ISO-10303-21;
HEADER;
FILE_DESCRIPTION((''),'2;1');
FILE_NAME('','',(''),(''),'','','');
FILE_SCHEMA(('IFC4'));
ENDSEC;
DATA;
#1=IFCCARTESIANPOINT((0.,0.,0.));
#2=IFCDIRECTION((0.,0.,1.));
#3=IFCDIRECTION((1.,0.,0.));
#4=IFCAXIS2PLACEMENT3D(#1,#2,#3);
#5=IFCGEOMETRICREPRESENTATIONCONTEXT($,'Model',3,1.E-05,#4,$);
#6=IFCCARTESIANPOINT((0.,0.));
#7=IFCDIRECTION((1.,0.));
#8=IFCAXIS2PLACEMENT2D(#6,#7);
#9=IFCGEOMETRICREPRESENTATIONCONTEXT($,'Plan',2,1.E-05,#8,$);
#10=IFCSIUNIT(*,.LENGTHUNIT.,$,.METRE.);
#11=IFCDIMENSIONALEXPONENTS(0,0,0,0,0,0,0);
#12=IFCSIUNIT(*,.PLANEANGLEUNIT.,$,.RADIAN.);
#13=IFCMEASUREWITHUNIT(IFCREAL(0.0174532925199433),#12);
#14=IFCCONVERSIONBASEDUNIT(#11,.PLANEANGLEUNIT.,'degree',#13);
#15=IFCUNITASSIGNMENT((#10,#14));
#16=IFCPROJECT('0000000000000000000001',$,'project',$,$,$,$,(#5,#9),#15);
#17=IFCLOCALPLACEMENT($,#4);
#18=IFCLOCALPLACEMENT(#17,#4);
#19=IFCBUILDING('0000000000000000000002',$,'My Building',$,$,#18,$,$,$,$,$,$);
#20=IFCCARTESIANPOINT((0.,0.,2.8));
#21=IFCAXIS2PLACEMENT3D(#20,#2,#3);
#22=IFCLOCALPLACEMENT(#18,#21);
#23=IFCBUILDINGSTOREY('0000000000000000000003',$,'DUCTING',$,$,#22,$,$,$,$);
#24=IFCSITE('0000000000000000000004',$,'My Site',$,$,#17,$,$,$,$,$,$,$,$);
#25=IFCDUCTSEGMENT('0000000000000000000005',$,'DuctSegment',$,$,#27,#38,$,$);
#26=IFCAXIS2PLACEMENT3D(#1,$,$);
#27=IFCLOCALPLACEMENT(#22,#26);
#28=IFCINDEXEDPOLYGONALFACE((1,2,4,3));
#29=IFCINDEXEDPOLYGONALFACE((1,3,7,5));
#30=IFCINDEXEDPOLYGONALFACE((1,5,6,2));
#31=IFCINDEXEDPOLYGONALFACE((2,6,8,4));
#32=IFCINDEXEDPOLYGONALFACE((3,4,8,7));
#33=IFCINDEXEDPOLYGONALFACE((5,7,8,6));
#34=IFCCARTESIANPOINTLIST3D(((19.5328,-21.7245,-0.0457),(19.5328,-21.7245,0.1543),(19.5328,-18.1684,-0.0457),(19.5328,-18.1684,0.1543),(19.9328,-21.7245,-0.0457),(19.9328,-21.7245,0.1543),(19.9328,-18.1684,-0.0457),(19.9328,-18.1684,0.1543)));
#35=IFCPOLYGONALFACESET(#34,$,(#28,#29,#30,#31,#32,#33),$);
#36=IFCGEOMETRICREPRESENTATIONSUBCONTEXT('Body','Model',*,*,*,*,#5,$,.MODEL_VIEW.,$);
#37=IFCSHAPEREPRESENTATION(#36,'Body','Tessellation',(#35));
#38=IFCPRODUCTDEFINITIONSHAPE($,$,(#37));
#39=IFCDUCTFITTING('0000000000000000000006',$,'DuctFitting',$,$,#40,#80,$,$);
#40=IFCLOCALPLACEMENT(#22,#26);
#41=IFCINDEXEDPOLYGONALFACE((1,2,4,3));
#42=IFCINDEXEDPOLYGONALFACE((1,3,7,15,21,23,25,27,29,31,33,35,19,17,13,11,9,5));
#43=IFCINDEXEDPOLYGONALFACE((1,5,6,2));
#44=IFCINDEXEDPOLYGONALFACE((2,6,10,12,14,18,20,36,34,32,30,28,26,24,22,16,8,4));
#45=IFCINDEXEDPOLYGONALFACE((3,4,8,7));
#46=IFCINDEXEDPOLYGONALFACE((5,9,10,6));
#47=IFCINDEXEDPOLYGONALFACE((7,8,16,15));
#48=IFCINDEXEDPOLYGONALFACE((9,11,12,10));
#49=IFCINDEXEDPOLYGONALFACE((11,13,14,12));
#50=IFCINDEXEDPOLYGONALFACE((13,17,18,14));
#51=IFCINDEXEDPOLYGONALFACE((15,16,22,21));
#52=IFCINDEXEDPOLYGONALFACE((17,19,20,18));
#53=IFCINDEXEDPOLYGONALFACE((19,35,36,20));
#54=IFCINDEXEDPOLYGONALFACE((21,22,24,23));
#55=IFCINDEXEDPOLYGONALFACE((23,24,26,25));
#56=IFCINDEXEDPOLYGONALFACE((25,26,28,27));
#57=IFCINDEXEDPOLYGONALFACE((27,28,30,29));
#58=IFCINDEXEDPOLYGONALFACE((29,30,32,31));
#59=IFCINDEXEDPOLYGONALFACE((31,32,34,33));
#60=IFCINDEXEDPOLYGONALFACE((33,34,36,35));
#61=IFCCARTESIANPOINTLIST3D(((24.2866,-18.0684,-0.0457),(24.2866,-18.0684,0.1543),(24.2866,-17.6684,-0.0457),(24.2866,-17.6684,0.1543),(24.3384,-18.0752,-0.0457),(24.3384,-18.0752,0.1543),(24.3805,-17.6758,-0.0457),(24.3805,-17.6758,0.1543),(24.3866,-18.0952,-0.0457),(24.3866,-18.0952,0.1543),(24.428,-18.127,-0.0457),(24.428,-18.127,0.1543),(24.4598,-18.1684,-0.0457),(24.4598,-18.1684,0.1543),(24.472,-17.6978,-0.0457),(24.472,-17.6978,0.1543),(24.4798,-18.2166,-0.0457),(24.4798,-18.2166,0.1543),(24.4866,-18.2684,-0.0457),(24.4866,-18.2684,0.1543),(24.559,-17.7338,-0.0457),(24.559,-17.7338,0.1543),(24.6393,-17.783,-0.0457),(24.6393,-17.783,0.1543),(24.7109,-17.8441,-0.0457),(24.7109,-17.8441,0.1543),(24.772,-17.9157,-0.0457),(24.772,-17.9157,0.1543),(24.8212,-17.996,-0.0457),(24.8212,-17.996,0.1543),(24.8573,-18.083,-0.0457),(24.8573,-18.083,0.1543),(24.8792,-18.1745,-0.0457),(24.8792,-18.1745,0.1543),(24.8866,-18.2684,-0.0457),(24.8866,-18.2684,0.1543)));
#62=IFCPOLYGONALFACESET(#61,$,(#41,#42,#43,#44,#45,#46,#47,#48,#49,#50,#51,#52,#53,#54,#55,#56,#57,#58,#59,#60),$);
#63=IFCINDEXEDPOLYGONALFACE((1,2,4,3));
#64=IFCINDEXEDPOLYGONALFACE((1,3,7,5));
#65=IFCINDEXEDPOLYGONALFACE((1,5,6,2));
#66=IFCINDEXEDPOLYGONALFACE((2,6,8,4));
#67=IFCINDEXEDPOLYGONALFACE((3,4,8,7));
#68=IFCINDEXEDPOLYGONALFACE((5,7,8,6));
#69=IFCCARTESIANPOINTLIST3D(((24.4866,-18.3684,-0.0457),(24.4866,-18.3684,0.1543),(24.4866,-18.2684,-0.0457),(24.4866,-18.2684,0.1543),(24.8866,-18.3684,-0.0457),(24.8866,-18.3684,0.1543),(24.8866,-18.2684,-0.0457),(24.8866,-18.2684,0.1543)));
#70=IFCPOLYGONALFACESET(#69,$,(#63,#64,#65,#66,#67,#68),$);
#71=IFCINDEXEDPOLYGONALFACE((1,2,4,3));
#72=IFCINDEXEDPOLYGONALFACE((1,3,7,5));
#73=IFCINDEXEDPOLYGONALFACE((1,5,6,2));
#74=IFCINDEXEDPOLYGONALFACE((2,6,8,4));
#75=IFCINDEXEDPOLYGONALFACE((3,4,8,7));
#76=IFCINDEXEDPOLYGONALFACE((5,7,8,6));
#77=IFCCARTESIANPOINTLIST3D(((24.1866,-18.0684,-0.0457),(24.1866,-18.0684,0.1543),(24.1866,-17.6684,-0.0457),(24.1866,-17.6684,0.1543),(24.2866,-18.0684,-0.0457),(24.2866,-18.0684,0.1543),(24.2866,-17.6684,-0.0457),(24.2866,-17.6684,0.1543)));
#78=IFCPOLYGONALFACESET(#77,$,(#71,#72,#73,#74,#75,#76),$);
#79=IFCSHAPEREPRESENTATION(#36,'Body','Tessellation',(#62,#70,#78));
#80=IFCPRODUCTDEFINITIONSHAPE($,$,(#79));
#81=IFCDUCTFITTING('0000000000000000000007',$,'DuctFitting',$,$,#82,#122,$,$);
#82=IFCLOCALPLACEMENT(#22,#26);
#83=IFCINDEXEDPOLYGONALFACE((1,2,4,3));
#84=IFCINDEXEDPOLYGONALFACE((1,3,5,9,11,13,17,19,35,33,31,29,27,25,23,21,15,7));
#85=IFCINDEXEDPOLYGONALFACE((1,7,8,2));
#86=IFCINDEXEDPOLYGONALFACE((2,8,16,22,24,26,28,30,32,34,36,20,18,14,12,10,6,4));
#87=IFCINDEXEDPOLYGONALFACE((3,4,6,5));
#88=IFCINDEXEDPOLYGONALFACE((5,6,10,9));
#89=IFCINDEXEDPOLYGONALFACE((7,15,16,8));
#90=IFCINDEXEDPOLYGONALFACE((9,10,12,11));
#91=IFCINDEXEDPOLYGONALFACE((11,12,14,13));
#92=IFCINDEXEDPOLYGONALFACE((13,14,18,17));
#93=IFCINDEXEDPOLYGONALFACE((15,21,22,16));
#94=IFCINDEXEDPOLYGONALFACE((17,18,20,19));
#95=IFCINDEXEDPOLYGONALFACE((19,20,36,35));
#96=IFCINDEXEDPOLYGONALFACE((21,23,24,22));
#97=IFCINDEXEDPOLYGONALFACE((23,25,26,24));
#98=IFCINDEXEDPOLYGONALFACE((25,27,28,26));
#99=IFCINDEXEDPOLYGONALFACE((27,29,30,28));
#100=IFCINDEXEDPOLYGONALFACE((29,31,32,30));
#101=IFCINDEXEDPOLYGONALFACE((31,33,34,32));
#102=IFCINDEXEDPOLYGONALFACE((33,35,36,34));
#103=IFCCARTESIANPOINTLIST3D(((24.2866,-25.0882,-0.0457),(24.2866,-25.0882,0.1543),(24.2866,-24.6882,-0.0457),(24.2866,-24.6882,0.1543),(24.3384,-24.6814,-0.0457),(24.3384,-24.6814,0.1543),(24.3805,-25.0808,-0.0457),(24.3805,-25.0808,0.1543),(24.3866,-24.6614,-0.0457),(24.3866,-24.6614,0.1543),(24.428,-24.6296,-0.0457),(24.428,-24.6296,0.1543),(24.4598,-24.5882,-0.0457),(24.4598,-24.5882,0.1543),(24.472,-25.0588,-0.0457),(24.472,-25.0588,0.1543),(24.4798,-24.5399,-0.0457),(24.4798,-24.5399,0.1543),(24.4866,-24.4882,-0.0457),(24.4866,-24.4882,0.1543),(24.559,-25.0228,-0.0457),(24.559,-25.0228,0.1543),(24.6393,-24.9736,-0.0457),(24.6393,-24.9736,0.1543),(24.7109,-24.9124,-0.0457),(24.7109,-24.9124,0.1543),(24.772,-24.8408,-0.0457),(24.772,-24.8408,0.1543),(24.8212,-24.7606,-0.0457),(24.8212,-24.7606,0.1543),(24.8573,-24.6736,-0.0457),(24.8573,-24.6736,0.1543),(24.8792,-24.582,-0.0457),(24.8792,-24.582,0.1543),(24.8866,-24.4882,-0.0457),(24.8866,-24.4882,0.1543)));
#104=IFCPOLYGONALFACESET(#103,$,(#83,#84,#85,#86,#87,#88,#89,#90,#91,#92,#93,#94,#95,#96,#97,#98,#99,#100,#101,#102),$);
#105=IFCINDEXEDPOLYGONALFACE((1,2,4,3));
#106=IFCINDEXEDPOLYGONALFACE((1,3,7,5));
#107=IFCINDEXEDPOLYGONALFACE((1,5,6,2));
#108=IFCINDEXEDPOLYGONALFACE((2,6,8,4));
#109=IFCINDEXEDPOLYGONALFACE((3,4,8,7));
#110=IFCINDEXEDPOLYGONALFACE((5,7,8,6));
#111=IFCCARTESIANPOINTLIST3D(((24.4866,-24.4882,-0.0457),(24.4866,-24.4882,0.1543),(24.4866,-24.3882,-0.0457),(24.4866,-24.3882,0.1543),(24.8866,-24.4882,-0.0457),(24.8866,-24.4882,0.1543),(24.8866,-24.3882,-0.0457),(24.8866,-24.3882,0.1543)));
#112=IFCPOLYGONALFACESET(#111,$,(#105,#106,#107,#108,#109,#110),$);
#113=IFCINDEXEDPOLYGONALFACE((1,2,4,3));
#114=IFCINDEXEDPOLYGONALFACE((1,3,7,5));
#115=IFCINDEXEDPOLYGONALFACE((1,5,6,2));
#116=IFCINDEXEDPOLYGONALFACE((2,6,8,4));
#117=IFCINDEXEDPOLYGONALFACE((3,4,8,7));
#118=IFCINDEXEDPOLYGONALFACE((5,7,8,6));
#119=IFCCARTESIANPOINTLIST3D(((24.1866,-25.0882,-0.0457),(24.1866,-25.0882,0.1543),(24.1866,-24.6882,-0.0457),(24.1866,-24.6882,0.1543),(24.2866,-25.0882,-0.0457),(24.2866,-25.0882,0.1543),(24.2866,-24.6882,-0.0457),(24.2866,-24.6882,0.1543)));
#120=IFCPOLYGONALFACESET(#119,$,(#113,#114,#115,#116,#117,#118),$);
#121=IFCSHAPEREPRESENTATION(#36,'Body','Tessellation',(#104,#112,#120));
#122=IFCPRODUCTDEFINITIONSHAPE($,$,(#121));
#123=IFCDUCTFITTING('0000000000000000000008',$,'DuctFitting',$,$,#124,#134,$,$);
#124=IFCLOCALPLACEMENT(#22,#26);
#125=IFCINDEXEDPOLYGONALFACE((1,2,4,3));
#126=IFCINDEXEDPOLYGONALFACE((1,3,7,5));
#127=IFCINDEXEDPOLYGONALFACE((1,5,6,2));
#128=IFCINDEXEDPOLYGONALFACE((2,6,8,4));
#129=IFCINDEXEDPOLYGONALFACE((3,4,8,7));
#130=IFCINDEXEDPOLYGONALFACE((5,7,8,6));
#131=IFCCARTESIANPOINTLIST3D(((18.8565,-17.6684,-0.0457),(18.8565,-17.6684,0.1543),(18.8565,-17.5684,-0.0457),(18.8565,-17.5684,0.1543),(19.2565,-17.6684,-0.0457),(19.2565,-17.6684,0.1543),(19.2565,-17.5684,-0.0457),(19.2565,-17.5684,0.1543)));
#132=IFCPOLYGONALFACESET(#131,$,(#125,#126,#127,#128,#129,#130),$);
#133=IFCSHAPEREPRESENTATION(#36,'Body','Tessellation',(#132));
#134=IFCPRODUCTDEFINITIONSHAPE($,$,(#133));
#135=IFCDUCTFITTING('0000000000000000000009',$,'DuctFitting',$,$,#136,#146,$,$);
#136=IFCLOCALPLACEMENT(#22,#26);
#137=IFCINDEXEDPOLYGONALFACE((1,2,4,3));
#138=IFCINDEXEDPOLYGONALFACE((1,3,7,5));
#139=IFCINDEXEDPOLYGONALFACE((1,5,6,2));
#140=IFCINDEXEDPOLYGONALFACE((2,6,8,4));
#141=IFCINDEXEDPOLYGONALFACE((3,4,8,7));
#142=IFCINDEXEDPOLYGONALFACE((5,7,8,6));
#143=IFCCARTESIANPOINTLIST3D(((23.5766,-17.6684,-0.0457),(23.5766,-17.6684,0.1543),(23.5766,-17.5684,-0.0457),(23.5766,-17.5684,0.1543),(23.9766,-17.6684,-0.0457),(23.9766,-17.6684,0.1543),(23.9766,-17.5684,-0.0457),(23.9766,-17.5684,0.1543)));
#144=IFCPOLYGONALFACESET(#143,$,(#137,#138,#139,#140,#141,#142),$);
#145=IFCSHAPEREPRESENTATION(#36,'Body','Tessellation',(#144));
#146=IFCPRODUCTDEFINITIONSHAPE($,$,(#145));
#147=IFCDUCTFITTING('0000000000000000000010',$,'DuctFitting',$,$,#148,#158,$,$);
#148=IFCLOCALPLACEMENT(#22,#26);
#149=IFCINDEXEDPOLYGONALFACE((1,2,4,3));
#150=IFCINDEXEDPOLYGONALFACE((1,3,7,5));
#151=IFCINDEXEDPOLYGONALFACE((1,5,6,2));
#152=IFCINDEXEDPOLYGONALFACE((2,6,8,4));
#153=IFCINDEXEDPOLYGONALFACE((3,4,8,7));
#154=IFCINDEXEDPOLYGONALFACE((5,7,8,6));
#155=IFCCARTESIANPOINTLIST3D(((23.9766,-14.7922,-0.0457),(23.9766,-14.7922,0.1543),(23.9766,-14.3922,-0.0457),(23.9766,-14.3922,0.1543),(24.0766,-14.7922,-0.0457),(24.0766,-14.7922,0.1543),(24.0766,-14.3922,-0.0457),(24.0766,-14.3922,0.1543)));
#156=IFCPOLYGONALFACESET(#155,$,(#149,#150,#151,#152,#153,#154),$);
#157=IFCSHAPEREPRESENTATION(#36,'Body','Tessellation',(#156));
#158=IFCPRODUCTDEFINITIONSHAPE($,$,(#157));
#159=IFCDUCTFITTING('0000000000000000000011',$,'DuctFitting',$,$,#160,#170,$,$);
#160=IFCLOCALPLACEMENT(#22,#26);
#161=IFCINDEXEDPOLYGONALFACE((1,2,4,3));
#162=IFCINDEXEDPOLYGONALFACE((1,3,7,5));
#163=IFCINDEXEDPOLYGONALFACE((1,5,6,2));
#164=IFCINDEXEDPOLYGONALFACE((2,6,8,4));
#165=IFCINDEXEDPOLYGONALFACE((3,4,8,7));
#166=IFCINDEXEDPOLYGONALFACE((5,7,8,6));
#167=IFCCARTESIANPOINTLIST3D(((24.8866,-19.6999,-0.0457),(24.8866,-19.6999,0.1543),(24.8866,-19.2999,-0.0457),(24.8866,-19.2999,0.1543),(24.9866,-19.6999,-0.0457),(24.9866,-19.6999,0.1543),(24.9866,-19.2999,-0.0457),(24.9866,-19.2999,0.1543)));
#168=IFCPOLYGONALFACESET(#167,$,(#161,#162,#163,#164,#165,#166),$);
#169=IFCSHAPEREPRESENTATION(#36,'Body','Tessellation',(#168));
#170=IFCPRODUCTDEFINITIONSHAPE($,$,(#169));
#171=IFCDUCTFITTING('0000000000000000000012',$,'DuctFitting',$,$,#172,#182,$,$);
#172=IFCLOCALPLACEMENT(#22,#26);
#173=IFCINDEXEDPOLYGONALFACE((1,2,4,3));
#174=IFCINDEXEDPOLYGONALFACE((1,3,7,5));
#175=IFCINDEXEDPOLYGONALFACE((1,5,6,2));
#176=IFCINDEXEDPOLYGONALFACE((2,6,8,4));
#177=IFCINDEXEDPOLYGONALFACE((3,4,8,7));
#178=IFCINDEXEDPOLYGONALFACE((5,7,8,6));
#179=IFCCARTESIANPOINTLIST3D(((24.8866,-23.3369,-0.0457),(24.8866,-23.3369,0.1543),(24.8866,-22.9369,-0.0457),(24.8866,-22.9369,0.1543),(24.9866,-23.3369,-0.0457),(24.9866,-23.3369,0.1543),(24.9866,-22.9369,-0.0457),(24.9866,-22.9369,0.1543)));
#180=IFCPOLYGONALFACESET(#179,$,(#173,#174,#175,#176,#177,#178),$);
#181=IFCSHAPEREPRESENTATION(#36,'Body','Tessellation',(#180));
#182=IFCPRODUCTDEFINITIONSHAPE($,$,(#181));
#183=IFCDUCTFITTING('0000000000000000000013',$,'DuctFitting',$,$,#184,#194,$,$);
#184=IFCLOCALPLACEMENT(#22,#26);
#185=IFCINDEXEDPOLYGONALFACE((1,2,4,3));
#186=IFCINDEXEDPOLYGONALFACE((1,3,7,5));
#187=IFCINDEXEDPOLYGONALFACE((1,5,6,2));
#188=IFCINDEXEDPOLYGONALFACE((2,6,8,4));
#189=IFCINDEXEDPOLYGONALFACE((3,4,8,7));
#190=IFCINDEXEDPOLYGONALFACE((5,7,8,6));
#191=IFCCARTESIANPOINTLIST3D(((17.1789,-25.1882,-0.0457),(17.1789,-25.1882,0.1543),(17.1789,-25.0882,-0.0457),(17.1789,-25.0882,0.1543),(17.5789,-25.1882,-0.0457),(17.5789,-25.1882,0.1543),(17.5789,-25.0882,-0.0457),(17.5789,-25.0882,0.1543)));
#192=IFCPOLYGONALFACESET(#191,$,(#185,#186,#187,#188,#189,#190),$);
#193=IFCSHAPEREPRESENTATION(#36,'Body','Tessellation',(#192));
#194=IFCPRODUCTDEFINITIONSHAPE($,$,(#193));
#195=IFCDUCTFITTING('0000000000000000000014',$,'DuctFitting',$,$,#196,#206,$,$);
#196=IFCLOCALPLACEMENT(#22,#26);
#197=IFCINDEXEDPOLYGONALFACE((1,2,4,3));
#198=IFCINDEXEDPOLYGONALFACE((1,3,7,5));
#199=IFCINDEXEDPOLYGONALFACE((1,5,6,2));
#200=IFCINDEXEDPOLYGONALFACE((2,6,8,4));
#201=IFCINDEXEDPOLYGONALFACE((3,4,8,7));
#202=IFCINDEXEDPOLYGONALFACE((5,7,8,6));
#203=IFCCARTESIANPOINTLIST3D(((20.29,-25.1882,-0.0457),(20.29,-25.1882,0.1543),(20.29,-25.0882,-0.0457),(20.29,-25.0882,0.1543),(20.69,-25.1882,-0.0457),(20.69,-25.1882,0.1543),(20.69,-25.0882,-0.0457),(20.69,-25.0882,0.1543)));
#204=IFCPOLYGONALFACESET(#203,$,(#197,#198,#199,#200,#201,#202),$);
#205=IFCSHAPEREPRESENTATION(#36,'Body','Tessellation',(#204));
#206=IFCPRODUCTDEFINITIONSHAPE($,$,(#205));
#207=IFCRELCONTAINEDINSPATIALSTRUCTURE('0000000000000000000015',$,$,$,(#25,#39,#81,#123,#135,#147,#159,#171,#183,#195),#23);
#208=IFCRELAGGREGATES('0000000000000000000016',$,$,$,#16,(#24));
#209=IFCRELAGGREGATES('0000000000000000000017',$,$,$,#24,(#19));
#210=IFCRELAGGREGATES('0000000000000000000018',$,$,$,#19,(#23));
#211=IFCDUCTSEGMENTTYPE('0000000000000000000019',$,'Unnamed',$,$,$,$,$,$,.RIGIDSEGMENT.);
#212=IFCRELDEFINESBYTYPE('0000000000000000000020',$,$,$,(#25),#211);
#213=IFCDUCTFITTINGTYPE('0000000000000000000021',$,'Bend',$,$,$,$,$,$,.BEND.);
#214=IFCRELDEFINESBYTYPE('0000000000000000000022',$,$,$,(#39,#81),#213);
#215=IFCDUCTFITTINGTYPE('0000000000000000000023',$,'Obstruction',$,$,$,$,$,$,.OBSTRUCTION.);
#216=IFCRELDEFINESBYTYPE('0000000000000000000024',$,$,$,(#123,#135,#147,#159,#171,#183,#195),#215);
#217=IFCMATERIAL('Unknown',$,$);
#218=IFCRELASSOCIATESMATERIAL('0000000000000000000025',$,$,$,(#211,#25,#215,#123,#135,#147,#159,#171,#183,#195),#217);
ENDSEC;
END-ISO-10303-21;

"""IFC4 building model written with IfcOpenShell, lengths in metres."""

from ifc_helpers import new_model, entity, si_unit, converted_unit, frame, origin_with_axes, origin_2d_with_axis, place, context, subcontext, project, spatial, line, arc, indexed_curve, rectangle, outline, extrude, source, transform, mapped, material, material_profile, profile_set, profile_usage, type_object, type_shapes, element, save


model = new_model("IFC4")

# Units and contexts
model_context = context("Model", 3, precision=1e-05, world=origin_with_axes())
plan_context = context("Plan", 2, precision=1e-05, world=origin_2d_with_axis())
body_context = subcontext(model_context, "Body", "Model", "MODEL_VIEW")
ifc_project = project(units=[si_unit("LENGTHUNIT", "METRE"), converted_unit("PLANEANGLEUNIT", "degree", entity("IfcReal", 0.0174532925199433), si_unit("PLANEANGLEUNIT", "RADIAN"), dimensions=[0, 0, 0, 0, 0, 0, 0])], contexts=[model_context, plan_context])

# Site, building, storey
site_placement = place(None, origin_with_axes())
site = spatial("IfcSite", under=ifc_project, at=site_placement, Name="My Site")
building_placement = place(site_placement, origin_with_axes())
building = spatial("IfcBuilding", under=site, at=building_placement, Name="My Building")
storey_placement = place(building_placement, frame((0.0, 0.0, 2.8), z_axis=(0.0, 0.0, 1.0), x_axis=(1.0, 0.0, 0.0)))
storey = spatial("IfcBuildingStorey", under=building, at=storey_placement, Name="DUCTING")

# Duct segment
ifc_material = material(Name="Unknown")
ifc_material_profile_1 = material_profile(ifc_material, rectangle(XDim=0.4, YDim=0.2))
ifc_profile_set_1 = profile_set([ifc_material_profile_1])
duct_segment_type = type_object("IfcDuctSegmentType", Name="Unnamed", PredefinedType="RIGIDSEGMENT", material=ifc_profile_set_1)
ifc_profile_usage_1 = profile_usage(ifc_profile_set_1, cardinal=5)
duct_segment_1_placement = place(storey_placement, frame((19.7328, -21.7245, 0.0543), z_axis=(0.0, 1.0, 0.0), x_axis=(-1.0, 0.0, 0.0)))
element("IfcDuctSegment", 1, at=duct_segment_1_placement, inside=storey, type_object=duct_segment_type, material=ifc_profile_usage_1, Name="DuctSegment", context=body_context, shape_type="SweptSolid", body=[
    extrude(rectangle(XDim=0.4, YDim=0.2), origin_with_axes(), (0.0, 0.0, 1.0), 3.5561),
])

# Duct fittings
duct_fitting_type_1 = type_object("IfcDuctFittingType", Name="Bend", PredefinedType="BEND")
shared_shape = source(origin_with_axes(), body_context, "Body", "SweptSolid", [
    extrude(outline(indexed_curve([(0.2, 0.0), (0.2586, -0.1414), (0.4, -0.2), (0.4, -0.6), (-0.0243, -0.4243), (-0.2, 0.0)], segments=[arc(1, 2, 3), line(3, 4), arc(4, 5, 6), line(6, 1)])), frame((0.0, -0.1, -0.1), z_axis=(0.0, -1.0, 0.0), x_axis=(1.0, 0.0, 0.0)), (0.0, 0.0, -1.0), 0.2),
    extrude(rectangle(XDim=0.4, YDim=0.2), origin_with_axes(), (0.0, 0.0, -1.0), 0.1),
    extrude(rectangle(XDim=0.4, YDim=0.2), frame((0.4, 0.0, -0.5), z_axis=(1.0, 0.0, 0.0), x_axis=(0.0, 0.0, 1.0)), (0.0, 0.0, 1.0), 0.1),
])
type_shapes(duct_fitting_type_1, [shared_shape])
for number, where, z_axis, x_axis, name in (
    (2, (24.6866, -18.3684, 0.0543), (0.0, -1.0, 0.0), (-1.0, 0.0, 0.0), "DuctFitting"),
    (3, (24.6866, -24.3882, 0.0543), (0.0, 1.0, 0.0), (-1.0, 0.0, 0.0), "DuctFitting"),
):
    element("IfcDuctFitting", number, at=place(storey_placement, frame(where, z_axis=z_axis, x_axis=x_axis)), inside=storey, type_object=duct_fitting_type_1, Name=name, context=body_context, shape_type="MappedRepresentation", body=[
        mapped(shared_shape, transform((0.0, 0.0, 0.0), x_axis=(1.0, 0.0, 0.0), y_axis=(0.0, 1.0, 0.0), z_axis=(0.0, 0.0, 1.0), scale=1.0)),
    ])
ifc_material_profile_2 = material_profile(ifc_material, rectangle(XDim=0.4, YDim=0.2))
ifc_profile_set_2 = profile_set([ifc_material_profile_2])
ifc_profile_usage_2 = profile_usage(ifc_profile_set_2, cardinal=5)
duct_fitting_type_2 = type_object("IfcDuctFittingType", Name="Obstruction", PredefinedType="OBSTRUCTION", material=ifc_profile_set_2)
duct_fitting_1_placement = place(storey_placement, frame((19.0565, -17.5684, 0.0543), z_axis=(0.0, -1.0, 0.0), x_axis=(1.0, 0.0, 0.0)))
element("IfcDuctFitting", 4, at=duct_fitting_1_placement, inside=storey, type_object=duct_fitting_type_2, material=ifc_profile_usage_2, Name="DuctFitting", context=body_context, shape_type="SweptSolid", body=[
    extrude(rectangle(XDim=0.4, YDim=0.2), origin_with_axes(), (0.0, 0.0, 1.0), 0.1),
])
ifc_profile_usage_3 = profile_usage(ifc_profile_set_2, cardinal=5)
duct_fitting_2_placement = place(storey_placement, frame((23.7766, -17.5684, 0.0543), z_axis=(0.0, -1.0, 0.0), x_axis=(1.0, 0.0, 0.0)))
element("IfcDuctFitting", 5, at=duct_fitting_2_placement, inside=storey, type_object=duct_fitting_type_2, material=ifc_profile_usage_3, Name="DuctFitting", context=body_context, shape_type="SweptSolid", body=[
    extrude(rectangle(XDim=0.4, YDim=0.2), origin_with_axes(), (0.0, 0.0, 1.0), 0.1),
])
ifc_profile_usage_4 = profile_usage(ifc_profile_set_2, cardinal=5)
duct_fitting_3_placement = place(storey_placement, frame((24.0766, -14.5922, 0.0543), z_axis=(-1.0, 0.0, 0.0), x_axis=(0.0, -1.0, 0.0)))
element("IfcDuctFitting", 6, at=duct_fitting_3_placement, inside=storey, type_object=duct_fitting_type_2, material=ifc_profile_usage_4, Name="DuctFitting", context=body_context, shape_type="SweptSolid", body=[
    extrude(rectangle(XDim=0.4, YDim=0.2), origin_with_axes(), (0.0, 0.0, 1.0), 0.1),
])
ifc_profile_usage_5 = profile_usage(ifc_profile_set_2, cardinal=5)
duct_fitting_4_placement = place(storey_placement, frame((24.9866, -19.4999, 0.0543), z_axis=(-1.0, 0.0, 0.0), x_axis=(0.0, -1.0, 0.0)))
element("IfcDuctFitting", 7, at=duct_fitting_4_placement, inside=storey, type_object=duct_fitting_type_2, material=ifc_profile_usage_5, Name="DuctFitting", context=body_context, shape_type="SweptSolid", body=[
    extrude(rectangle(XDim=0.4, YDim=0.2), origin_with_axes(), (0.0, 0.0, 1.0), 0.1),
])
ifc_profile_usage_6 = profile_usage(ifc_profile_set_2, cardinal=5)
duct_fitting_5_placement = place(storey_placement, frame((24.9866, -23.1369, 0.0543), z_axis=(-1.0, 0.0, 0.0), x_axis=(0.0, -1.0, 0.0)))
element("IfcDuctFitting", 8, at=duct_fitting_5_placement, inside=storey, type_object=duct_fitting_type_2, material=ifc_profile_usage_6, Name="DuctFitting", context=body_context, shape_type="SweptSolid", body=[
    extrude(rectangle(XDim=0.4, YDim=0.2), origin_with_axes(), (0.0, 0.0, 1.0), 0.1),
])
ifc_profile_usage_7 = profile_usage(ifc_profile_set_2, cardinal=5)
duct_fitting_6_placement = place(storey_placement, frame((17.3789, -25.1882, 0.0543), z_axis=(0.0, 1.0, 0.0), x_axis=(-1.0, 0.0, 0.0)))
element("IfcDuctFitting", 9, at=duct_fitting_6_placement, inside=storey, type_object=duct_fitting_type_2, material=ifc_profile_usage_7, Name="DuctFitting", context=body_context, shape_type="SweptSolid", body=[
    extrude(rectangle(XDim=0.4, YDim=0.2), origin_with_axes(), (0.0, 0.0, 1.0), 0.1),
])
ifc_profile_usage_8 = profile_usage(ifc_profile_set_2, cardinal=5)
duct_fitting_7_placement = place(storey_placement, frame((20.49, -25.1882, 0.0543), z_axis=(0.0, 1.0, 0.0), x_axis=(-1.0, 0.0, 0.0)))
element("IfcDuctFitting", 10, at=duct_fitting_7_placement, inside=storey, type_object=duct_fitting_type_2, material=ifc_profile_usage_8, Name="DuctFitting", context=body_context, shape_type="SweptSolid", body=[
    extrude(rectangle(XDim=0.4, YDim=0.2), origin_with_axes(), (0.0, 0.0, 1.0), 0.1),
])

save(model, "model.ifc")
